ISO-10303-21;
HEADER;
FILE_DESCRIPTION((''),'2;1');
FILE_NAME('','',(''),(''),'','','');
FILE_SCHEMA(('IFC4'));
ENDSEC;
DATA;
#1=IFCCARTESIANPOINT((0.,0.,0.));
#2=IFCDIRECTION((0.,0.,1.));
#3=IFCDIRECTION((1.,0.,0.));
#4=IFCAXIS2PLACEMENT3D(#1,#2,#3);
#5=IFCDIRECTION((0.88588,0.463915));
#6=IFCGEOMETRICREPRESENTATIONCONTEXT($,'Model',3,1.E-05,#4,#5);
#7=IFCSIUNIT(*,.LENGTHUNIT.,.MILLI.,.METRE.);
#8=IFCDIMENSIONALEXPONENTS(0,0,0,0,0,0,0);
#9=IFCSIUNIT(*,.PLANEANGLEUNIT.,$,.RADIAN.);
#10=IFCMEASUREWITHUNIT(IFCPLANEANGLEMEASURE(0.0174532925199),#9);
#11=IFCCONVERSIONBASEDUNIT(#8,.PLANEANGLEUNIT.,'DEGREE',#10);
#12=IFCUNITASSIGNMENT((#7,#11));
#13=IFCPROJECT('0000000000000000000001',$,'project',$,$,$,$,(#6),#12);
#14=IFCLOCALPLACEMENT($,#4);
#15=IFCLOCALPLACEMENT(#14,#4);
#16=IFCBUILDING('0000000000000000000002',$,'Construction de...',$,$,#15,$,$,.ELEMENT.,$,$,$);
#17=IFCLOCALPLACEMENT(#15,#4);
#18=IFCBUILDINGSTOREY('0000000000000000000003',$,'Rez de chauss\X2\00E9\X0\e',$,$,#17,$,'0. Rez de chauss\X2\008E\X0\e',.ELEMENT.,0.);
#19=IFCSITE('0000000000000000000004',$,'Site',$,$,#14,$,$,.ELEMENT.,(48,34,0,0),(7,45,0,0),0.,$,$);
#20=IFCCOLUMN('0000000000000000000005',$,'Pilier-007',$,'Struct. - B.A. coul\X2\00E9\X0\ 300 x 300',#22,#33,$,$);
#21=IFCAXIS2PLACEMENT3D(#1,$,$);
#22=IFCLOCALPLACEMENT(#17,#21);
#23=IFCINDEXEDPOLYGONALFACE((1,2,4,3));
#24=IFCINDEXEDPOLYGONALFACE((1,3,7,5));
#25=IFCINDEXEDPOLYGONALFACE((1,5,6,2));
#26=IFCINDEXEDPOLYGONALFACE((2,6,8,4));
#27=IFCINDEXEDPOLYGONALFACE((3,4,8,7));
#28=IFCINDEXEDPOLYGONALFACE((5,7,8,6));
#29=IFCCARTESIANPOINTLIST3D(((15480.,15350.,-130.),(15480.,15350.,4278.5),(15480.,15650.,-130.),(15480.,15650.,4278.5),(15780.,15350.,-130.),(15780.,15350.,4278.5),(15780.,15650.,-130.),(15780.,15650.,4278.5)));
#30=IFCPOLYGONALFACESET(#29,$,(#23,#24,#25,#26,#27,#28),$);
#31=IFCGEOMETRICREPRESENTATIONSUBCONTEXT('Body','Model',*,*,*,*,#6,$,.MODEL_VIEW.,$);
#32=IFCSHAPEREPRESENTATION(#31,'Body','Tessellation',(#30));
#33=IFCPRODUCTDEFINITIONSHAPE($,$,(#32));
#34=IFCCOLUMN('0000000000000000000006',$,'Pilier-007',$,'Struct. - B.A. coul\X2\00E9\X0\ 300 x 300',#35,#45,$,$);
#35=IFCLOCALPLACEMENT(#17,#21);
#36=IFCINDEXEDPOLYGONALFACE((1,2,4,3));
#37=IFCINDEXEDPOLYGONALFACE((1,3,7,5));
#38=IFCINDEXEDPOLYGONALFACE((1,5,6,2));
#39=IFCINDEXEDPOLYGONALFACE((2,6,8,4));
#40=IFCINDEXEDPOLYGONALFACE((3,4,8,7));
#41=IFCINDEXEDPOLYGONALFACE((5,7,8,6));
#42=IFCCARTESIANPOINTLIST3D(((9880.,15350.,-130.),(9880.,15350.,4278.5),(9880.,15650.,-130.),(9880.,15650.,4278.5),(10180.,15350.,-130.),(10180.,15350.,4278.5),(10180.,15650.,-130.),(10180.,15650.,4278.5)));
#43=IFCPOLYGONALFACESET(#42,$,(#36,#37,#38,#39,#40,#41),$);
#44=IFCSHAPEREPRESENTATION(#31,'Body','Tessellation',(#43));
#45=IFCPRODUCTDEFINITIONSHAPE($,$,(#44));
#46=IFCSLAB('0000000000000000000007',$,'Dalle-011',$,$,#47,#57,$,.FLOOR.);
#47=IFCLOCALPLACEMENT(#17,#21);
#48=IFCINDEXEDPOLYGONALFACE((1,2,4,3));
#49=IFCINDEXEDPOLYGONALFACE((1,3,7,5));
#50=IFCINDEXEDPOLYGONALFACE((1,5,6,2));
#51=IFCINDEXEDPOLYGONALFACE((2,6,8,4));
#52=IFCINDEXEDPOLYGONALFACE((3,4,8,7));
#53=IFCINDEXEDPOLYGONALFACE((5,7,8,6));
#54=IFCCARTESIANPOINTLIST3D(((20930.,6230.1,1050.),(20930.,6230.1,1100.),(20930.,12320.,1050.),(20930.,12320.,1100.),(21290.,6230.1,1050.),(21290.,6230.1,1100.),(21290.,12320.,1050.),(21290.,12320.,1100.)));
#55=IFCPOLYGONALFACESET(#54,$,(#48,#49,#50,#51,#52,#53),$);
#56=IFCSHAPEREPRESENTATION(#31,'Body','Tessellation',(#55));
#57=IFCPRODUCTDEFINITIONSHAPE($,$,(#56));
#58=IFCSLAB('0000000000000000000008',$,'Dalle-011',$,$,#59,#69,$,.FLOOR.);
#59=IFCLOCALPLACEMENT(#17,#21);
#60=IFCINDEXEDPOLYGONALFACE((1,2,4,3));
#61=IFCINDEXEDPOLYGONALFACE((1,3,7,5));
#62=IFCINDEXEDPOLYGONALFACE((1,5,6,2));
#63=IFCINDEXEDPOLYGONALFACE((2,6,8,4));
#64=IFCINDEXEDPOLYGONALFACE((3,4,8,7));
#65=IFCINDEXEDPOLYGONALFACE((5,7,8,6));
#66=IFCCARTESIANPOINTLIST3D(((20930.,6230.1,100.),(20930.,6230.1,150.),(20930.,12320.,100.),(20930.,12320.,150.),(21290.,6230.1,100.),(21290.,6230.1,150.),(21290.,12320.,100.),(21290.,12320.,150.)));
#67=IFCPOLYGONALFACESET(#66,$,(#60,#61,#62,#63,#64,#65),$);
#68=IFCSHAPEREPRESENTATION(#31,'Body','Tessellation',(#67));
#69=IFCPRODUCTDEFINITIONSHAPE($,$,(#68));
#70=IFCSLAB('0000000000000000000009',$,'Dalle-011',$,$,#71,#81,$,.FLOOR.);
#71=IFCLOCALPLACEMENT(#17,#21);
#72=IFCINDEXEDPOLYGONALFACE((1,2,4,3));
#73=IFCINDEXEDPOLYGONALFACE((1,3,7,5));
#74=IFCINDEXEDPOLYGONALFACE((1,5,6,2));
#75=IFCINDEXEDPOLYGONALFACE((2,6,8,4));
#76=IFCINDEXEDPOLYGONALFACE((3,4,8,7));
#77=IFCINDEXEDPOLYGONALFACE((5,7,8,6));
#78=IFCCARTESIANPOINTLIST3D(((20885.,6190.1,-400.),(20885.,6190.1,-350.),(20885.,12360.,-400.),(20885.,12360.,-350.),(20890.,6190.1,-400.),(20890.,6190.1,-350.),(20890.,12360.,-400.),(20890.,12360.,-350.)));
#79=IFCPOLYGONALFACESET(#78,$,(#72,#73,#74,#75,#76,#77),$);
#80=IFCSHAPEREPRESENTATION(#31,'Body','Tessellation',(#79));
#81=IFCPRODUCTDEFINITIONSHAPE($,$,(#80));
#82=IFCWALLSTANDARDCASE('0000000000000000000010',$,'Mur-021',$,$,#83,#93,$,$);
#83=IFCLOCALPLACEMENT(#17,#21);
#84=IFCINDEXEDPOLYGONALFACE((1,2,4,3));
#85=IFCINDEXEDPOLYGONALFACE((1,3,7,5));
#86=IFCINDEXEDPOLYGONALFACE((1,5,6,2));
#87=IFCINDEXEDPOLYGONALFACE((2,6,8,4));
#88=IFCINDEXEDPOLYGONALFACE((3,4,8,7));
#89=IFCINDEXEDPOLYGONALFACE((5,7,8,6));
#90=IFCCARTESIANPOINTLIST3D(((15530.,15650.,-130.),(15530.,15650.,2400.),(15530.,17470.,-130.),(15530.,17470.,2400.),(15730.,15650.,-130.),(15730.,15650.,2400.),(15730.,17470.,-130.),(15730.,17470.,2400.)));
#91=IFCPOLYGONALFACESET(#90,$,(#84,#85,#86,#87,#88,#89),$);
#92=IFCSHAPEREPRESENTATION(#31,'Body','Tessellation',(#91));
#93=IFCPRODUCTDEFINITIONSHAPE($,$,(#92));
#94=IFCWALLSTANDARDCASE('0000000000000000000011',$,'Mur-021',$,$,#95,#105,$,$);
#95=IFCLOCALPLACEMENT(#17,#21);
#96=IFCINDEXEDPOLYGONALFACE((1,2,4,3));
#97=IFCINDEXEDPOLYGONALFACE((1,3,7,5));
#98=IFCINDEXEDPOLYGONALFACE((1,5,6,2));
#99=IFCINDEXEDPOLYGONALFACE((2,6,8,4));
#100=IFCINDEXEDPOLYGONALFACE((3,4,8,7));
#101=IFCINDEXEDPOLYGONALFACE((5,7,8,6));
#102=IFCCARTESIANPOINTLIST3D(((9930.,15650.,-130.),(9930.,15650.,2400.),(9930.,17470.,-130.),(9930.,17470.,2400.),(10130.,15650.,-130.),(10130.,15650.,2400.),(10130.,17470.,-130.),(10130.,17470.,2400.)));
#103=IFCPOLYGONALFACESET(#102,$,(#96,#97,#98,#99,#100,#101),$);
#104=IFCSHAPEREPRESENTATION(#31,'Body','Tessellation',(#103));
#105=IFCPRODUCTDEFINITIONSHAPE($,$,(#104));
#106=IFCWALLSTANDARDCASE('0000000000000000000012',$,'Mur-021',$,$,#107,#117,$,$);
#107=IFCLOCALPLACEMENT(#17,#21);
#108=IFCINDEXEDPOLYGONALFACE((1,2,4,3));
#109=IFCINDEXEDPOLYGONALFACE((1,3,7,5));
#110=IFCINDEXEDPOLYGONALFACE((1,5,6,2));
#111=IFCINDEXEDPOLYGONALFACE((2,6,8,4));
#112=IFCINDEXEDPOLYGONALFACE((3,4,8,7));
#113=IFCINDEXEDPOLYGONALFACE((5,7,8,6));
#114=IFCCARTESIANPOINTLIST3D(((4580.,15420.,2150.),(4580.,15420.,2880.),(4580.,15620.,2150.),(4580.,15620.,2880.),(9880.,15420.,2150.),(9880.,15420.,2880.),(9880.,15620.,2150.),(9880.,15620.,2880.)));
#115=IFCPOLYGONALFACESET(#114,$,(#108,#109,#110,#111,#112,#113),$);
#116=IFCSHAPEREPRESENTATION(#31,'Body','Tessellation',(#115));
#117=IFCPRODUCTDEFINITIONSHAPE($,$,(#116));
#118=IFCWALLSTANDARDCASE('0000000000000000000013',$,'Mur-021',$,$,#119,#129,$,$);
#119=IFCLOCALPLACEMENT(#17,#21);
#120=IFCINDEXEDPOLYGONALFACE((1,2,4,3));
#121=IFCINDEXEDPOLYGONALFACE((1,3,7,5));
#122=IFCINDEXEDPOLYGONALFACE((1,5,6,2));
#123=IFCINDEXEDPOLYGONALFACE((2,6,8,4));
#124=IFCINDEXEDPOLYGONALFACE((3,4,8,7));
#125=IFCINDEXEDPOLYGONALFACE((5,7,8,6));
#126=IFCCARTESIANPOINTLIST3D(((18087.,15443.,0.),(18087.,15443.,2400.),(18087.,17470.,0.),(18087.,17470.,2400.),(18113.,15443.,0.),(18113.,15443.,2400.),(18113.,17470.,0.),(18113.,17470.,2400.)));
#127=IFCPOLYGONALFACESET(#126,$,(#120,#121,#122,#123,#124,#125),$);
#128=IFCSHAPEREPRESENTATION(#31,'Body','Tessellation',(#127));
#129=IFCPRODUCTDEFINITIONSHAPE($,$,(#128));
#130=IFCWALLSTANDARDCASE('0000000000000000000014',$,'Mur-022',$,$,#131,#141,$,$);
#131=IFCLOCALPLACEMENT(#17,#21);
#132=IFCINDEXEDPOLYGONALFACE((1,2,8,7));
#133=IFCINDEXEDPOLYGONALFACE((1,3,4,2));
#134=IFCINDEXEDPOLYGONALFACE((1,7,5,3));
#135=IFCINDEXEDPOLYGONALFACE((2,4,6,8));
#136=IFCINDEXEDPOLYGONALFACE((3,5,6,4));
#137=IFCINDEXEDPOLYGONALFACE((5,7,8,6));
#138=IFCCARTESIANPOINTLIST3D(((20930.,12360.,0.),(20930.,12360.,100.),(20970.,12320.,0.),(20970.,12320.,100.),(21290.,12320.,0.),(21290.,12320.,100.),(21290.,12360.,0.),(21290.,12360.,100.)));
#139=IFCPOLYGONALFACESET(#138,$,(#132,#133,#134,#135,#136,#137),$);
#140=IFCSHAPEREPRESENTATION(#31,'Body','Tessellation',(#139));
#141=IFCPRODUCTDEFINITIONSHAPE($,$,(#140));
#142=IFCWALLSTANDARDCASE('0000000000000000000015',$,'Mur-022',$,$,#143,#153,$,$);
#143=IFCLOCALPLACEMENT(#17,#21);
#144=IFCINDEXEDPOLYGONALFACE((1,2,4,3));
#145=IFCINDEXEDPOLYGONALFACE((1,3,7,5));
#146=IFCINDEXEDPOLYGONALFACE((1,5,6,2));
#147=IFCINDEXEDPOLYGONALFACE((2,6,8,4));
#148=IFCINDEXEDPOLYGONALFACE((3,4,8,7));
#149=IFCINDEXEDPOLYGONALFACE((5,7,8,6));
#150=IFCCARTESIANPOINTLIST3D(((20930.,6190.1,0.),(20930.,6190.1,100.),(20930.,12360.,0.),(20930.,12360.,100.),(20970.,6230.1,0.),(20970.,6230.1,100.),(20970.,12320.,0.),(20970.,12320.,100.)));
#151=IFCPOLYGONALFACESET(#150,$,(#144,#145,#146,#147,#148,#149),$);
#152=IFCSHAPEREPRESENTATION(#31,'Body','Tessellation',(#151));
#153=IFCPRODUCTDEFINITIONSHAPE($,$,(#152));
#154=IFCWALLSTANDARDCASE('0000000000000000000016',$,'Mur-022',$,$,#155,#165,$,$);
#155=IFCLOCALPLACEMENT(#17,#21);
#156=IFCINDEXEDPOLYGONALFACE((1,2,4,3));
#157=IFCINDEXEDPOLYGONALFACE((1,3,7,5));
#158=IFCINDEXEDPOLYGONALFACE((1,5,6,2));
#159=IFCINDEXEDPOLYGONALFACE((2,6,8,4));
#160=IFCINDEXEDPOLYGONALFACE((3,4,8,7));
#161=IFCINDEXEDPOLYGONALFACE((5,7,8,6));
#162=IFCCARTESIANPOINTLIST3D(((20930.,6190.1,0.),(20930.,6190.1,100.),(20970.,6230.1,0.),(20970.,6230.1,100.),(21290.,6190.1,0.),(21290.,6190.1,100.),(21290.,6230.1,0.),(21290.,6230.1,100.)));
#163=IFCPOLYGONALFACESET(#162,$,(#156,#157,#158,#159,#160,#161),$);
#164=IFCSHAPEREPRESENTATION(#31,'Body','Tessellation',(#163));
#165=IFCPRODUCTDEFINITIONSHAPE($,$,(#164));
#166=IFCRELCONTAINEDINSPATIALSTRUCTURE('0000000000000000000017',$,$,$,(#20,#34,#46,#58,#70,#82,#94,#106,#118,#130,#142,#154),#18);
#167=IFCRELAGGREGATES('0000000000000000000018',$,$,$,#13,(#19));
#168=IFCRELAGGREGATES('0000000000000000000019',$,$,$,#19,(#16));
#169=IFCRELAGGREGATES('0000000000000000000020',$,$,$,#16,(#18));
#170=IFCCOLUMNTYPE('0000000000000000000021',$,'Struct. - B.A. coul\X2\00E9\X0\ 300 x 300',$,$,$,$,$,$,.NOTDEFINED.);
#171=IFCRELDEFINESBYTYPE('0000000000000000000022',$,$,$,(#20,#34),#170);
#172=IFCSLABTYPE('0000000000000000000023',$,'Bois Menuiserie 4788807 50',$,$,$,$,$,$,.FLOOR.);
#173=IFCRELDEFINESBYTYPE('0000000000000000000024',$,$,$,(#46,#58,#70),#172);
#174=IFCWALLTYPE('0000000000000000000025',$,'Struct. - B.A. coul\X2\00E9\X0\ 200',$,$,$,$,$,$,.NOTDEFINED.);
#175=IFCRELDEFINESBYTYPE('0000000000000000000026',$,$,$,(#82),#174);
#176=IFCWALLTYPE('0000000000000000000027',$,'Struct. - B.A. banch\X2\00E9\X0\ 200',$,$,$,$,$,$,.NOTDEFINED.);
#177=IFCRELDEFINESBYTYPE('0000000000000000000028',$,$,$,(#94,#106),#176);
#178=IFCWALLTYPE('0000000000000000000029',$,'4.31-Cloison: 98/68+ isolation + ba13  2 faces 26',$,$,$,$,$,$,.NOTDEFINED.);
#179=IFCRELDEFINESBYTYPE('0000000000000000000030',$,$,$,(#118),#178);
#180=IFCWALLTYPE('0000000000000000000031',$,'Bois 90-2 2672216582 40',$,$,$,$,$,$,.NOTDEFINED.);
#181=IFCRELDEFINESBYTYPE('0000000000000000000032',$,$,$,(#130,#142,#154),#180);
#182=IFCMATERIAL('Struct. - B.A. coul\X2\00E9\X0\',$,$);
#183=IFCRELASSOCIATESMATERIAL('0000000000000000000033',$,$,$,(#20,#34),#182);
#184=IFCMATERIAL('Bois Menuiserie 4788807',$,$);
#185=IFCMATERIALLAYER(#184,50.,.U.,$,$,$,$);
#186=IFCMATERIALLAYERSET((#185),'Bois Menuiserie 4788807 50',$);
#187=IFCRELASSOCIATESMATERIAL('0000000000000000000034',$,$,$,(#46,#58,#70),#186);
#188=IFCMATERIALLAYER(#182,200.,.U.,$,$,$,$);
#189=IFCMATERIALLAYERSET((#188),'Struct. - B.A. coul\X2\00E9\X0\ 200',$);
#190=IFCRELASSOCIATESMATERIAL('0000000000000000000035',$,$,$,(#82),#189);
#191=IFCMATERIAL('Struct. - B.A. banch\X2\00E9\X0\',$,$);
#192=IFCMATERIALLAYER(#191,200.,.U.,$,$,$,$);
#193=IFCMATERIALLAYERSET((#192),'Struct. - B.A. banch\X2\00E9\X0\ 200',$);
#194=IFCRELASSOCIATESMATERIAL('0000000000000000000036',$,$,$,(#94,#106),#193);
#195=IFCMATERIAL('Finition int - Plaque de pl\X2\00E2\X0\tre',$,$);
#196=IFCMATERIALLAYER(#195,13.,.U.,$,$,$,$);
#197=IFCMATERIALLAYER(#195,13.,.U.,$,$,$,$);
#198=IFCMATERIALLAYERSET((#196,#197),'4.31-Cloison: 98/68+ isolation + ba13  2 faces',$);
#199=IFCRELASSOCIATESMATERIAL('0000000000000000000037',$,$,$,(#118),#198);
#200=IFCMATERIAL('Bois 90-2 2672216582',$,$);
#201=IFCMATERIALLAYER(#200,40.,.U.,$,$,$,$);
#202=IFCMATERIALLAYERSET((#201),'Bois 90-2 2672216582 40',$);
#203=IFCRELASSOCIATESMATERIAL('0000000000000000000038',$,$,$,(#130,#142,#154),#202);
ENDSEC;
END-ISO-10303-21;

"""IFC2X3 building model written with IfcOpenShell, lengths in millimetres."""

from ifc_helpers import new_model, entity, si_unit, converted_unit, direction, frame, origin_with_axes, origin_2d_with_axis, place, context, subcontext, project, spatial, polyline, rectangle, outline, extrude, material, layer, layer_set, layer_usage, type_object, element, save


model = new_model("IFC2X3")

# Units and contexts
model_context = context("Model", 3, precision=1e-05, world=origin_with_axes(), true_north=direction((0.88588, 0.463915)))
body_context = subcontext(model_context, "Body", "Model", "MODEL_VIEW")
ifc_project = project(units=[si_unit("LENGTHUNIT", "METRE", prefix="MILLI"), converted_unit("PLANEANGLEUNIT", "DEGREE", entity("IfcPlaneAngleMeasure", 0.0174532925199), si_unit("PLANEANGLEUNIT", "RADIAN"), dimensions=[0, 0, 0, 0, 0, 0, 0])], contexts=[model_context])

# Site, building, storey
site_placement = place(None, origin_with_axes())
site = spatial("IfcSite", under=ifc_project, at=site_placement, Name="Site", CompositionType="ELEMENT", RefLatitude=(48, 34, 0, 0), RefLongitude=(7, 45, 0, 0), RefElevation=0.0)
building_placement = place(site_placement, origin_with_axes())
building = spatial("IfcBuilding", under=site, at=building_placement, Name="Construction de...", CompositionType="ELEMENT")
storey_placement = place(building_placement, origin_with_axes())
storey = spatial("IfcBuildingStorey", under=building, at=storey_placement, Name="Rez de chaussée", LongName="0. Rez de chauss\u008ee", CompositionType="ELEMENT", Elevation=0.0)

# Columns
ifc_material_1 = material(Name="Struct. - B.A. coulé")
column_type = type_object("IfcColumnType", Name="Struct. - B.A. coulé 300 x 300", PredefinedType="NOTDEFINED")
for number, where, z_axis, x_axis, name in (
    (1, (15630.0, 15500.0, -130.0), (0.0, 0.0, 1.0), (1.0, 0.0, 0.0), "Pilier-007"),
    (2, (10030.0, 15500.0, -130.0), (0.0, 0.0, 1.0), (1.0, 0.0, 0.0), "Pilier-007"),
):
    element("IfcColumn", number, at=place(storey_placement, frame(where, z_axis=z_axis, x_axis=x_axis)), inside=storey, type_object=column_type, material=ifc_material_1, Name=name, ObjectType="Struct. - B.A. coulé 300 x 300", context=body_context, shape_type="SweptSolid", body=[
        extrude(rectangle(XDim=300.0, YDim=300.0, at=origin_2d_with_axis()), origin_with_axes(), (0.0, 0.0, 1.0), 4408.5),
    ])

# Slabs
ifc_material_2 = material(Name="Bois Menuiserie 4788807")
ifc_layer_1 = layer(ifc_material_2, 50.0, ventilated="UNKNOWN")
ifc_layer_set_1 = layer_set([ifc_layer_1], Name="Bois Menuiserie 4788807 50")
ifc_layer_usage_1 = layer_usage(ifc_layer_set_1, "AXIS3", "NEGATIVE", 50.0)
slab_type = type_object("IfcSlabType", Name="Bois Menuiserie 4788807 50", PredefinedType="FLOOR")
slab_1_placement = place(storey_placement, frame((20930.0, 12320.0, 1100.0), z_axis=(0.0, 0.0, 1.0), x_axis=(1.0, 0.0, 0.0)))
element("IfcSlab", 3, at=slab_1_placement, inside=storey, type_object=slab_type, material=ifc_layer_usage_1, Name="Dalle-011", PredefinedType="FLOOR", context=body_context, shape_type="SweptSolid", body=[
    extrude(outline(polyline([(0.0, 0.0), (0.0, -6089.9), (360.0, -6089.9), (360.0, 0.0), (0.0, 0.0)])), frame((0.0, 0.0, -50.0), z_axis=(0.0, 0.0, 1.0), x_axis=(1.0, 0.0, 0.0)), (0.0, 0.0, 1.0), 50.0),
])
ifc_layer_usage_2 = layer_usage(ifc_layer_set_1, "AXIS3", "NEGATIVE", 50.0)
slab_2_placement = place(storey_placement, frame((20930.0, 12320.0, 150.0), z_axis=(0.0, 0.0, 1.0), x_axis=(1.0, 0.0, 0.0)))
element("IfcSlab", 4, at=slab_2_placement, inside=storey, type_object=slab_type, material=ifc_layer_usage_2, Name="Dalle-011", PredefinedType="FLOOR", context=body_context, shape_type="SweptSolid", body=[
    extrude(outline(polyline([(0.0, 0.0), (0.0, -6089.9), (360.0, -6089.9), (360.0, 0.0), (0.0, 0.0)])), frame((0.0, 0.0, -50.0), z_axis=(0.0, 0.0, 1.0), x_axis=(1.0, 0.0, 0.0)), (0.0, 0.0, 1.0), 50.0),
])
ifc_layer_usage_3 = layer_usage(ifc_layer_set_1, "AXIS3", "NEGATIVE", 50.0)
slab_3_placement = place(storey_placement, frame((20890.0, 12360.0, -350.0), z_axis=(0.0, 0.0, 1.0), x_axis=(1.0, 0.0, 0.0)))
element("IfcSlab", 5, at=slab_3_placement, inside=storey, type_object=slab_type, material=ifc_layer_usage_3, Name="Dalle-011", PredefinedType="FLOOR", context=body_context, shape_type="SweptSolid", body=[
    extrude(outline(polyline([(0.0, 0.0), (-5.0, 0.0), (-5.0, -6169.9), (0.0, -6169.9), (0.0, 0.0)])), frame((0.0, 0.0, -50.0), z_axis=(0.0, 0.0, 1.0), x_axis=(1.0, 0.0, 0.0)), (0.0, 0.0, 1.0), 50.0),
])

# Walls
ifc_layer_2 = layer(ifc_material_1, 200.0, ventilated="UNKNOWN")
ifc_layer_set_2 = layer_set([ifc_layer_2], Name="Struct. - B.A. coulé 200")
ifc_layer_usage_4 = layer_usage(ifc_layer_set_2, "AXIS2", "NEGATIVE", 100.0)
wall_type_1 = type_object("IfcWallType", Name="Struct. - B.A. coulé 200", PredefinedType="NOTDEFINED")
wall_1_placement = place(storey_placement, frame((15630.0, 17470.0, -130.0), z_axis=(0.0, 0.0, 1.0), x_axis=(0.0, -1.0, 0.0)))
element("IfcWallStandardCase", 6, at=wall_1_placement, inside=storey, type_object=wall_type_1, material=ifc_layer_usage_4, Name="Mur-021", context=body_context, shape_type="SweptSolid", body=[
    extrude(outline(polyline([(0.0, -100.0), (1820.0, -100.0), (1820.0, 100.0), (0.0, 100.0), (0.0, -100.0)])), origin_with_axes(), (0.0, 0.0, 1.0), 2530.0),
])
ifc_material_3 = material(Name="Struct. - B.A. banché")
ifc_layer_3 = layer(ifc_material_3, 200.0, ventilated="UNKNOWN")
ifc_layer_set_3 = layer_set([ifc_layer_3], Name="Struct. - B.A. banché 200")
ifc_layer_usage_5 = layer_usage(ifc_layer_set_3, "AXIS2", "NEGATIVE", 100.0)
wall_type_2 = type_object("IfcWallType", Name="Struct. - B.A. banché 200", PredefinedType="NOTDEFINED")
wall_2_placement = place(storey_placement, frame((10030.0, 17470.0, -130.0), z_axis=(0.0, 0.0, 1.0), x_axis=(0.0, -1.0, 0.0)))
element("IfcWallStandardCase", 7, at=wall_2_placement, inside=storey, type_object=wall_type_2, material=ifc_layer_usage_5, Name="Mur-021", context=body_context, shape_type="SweptSolid", body=[
    extrude(outline(polyline([(0.0, -100.0), (1820.0, -100.0), (1820.0, 100.0), (0.0, 100.0), (0.0, -100.0)])), origin_with_axes(), (0.0, 0.0, 1.0), 2530.0),
])

# Wall, opening
ifc_layer_usage_6 = layer_usage(ifc_layer_set_3, "AXIS2", "POSITIVE", -100.0)
wall_3_placement = place(storey_placement, frame((9880.0, 15520.0, 0.0), z_axis=(0.0, 0.0, 1.0), x_axis=(-1.0, 0.0, 0.0)))
wall_3 = element("IfcWallStandardCase", 8, at=wall_3_placement, inside=storey, type_object=wall_type_2, material=ifc_layer_usage_6, Name="Mur-021", context=body_context, shape_type="SweptSolid", body=[
    extrude(outline(polyline([(0.0, -100.0), (5300.0, -100.0), (5300.0, 100.0), (0.0, 100.0), (0.0, -100.0)])), origin_with_axes(), (0.0, 0.0, 1.0), 2880.0),
])
opening_1_placement = place(wall_3_placement, frame((2650.0, 0.0, 0.0), z_axis=(0.0, 0.0, 1.0), x_axis=(1.0, 0.0, 0.0)))
element("IfcOpeningElement", 9, at=opening_1_placement, cuts=wall_3, context=body_context, shape_type="SweptSolid", body=[
    extrude(rectangle(XDim=5400.0, YDim=2150.0, at=origin_2d_with_axis()), frame((0.0, -100.0, 1075.0), z_axis=(0.0, 1.0, 0.0), x_axis=(1.0, 0.0, 0.0)), (0.0, 0.0, -1.0), 200.0),
    extrude(rectangle(XDim=5400.0, YDim=2150.0, at=origin_2d_with_axis()), frame((0.0, -100.0, 1075.0), z_axis=(0.0, -1.0, 0.0), x_axis=(1.0, 0.0, 0.0)), (0.0, 0.0, -1.0), 200.0),
])

# Wall
ifc_material_4 = material(Name="Finition int - Plaque de plâtre")
ifc_layer_4 = layer(ifc_material_4, 13.0, ventilated="UNKNOWN")
ifc_layer_5 = layer(ifc_material_4, 13.0, ventilated="UNKNOWN")
ifc_layer_set_4 = layer_set([ifc_layer_4, ifc_layer_5], Name="4.31-Cloison: 98/68+ isolation + ba13  2 faces")
ifc_layer_usage_7 = layer_usage(ifc_layer_set_4, "AXIS2", "NEGATIVE", 13.0)
wall_type_3 = type_object("IfcWallType", Name="4.31-Cloison: 98/68+ isolation + ba13  2 faces 26", PredefinedType="NOTDEFINED")
wall_4_placement = place(storey_placement, frame((18100.0, 17470.0, 0.0), z_axis=(0.0, 0.0, 1.0), x_axis=(0.0, -1.0, 0.0)))
element("IfcWallStandardCase", 10, at=wall_4_placement, inside=storey, type_object=wall_type_3, material=ifc_layer_usage_7, Name="Mur-021", context=body_context, shape_type="SweptSolid", body=[
    extrude(outline(polyline([(0.0, -13.0), (2027.0, -13.0), (2027.0, 13.0), (0.0, 13.0), (0.0, -13.0)])), origin_with_axes(), (0.0, 0.0, 1.0), 2400.0),
])

# Walls
ifc_material_5 = material(Name="Bois 90-2 2672216582")
ifc_layer_6 = layer(ifc_material_5, 40.0, ventilated="UNKNOWN")
ifc_layer_set_5 = layer_set([ifc_layer_6], Name="Bois 90-2 2672216582 40")
ifc_layer_usage_8 = layer_usage(ifc_layer_set_5, "AXIS2", "POSITIVE", -20.0)
wall_type_4 = type_object("IfcWallType", Name="Bois 90-2 2672216582 40", PredefinedType="NOTDEFINED")
wall_5_placement = place(storey_placement, frame((20950.0, 12340.0, 0.0), z_axis=(0.0, 0.0, 1.0), x_axis=(1.0, 0.0, 0.0)))
element("IfcWallStandardCase", 11, at=wall_5_placement, inside=storey, type_object=wall_type_4, material=ifc_layer_usage_8, Name="Mur-022", context=body_context, shape_type="SweptSolid", body=[
    extrude(outline(polyline([(20.0, -20.0), (340.0, -20.0), (340.0, 20.0), (-20.0, 20.0), (20.0, -20.0)])), origin_with_axes(), (0.0, 0.0, 1.0), 100.0),
])
ifc_layer_usage_9 = layer_usage(ifc_layer_set_5, "AXIS2", "POSITIVE", -20.0)
wall_6_placement = place(storey_placement, frame((20950.0, 12340.0, 0.0), z_axis=(0.0, 0.0, 1.0), x_axis=(0.0, -1.0, 0.0)))
element("IfcWallStandardCase", 12, at=wall_6_placement, inside=storey, type_object=wall_type_4, material=ifc_layer_usage_9, Name="Mur-022", context=body_context, shape_type="SweptSolid", body=[
    extrude(outline(polyline([(-20.0, -20.0), (6149.9, -20.0), (6109.9, 20.0), (20.0, 20.0), (-20.0, -20.0)])), origin_with_axes(), (0.0, 0.0, 1.0), 100.0),
])
ifc_layer_usage_10 = layer_usage(ifc_layer_set_5, "AXIS2", "POSITIVE", -20.0)
wall_7_placement = place(storey_placement, frame((20950.0, 6210.1, 0.0), z_axis=(0.0, 0.0, 1.0), x_axis=(1.0, 0.0, 0.0)))
element("IfcWallStandardCase", 13, at=wall_7_placement, inside=storey, type_object=wall_type_4, material=ifc_layer_usage_10, Name="Mur-022", context=body_context, shape_type="SweptSolid", body=[
    extrude(outline(polyline([(-20.0, -20.0), (340.0, -20.0), (340.0, 20.0), (20.0, 20.0), (-20.0, -20.0)])), origin_with_axes(), (0.0, 0.0, 1.0), 100.0),
])

save(model, "model.ifc")
